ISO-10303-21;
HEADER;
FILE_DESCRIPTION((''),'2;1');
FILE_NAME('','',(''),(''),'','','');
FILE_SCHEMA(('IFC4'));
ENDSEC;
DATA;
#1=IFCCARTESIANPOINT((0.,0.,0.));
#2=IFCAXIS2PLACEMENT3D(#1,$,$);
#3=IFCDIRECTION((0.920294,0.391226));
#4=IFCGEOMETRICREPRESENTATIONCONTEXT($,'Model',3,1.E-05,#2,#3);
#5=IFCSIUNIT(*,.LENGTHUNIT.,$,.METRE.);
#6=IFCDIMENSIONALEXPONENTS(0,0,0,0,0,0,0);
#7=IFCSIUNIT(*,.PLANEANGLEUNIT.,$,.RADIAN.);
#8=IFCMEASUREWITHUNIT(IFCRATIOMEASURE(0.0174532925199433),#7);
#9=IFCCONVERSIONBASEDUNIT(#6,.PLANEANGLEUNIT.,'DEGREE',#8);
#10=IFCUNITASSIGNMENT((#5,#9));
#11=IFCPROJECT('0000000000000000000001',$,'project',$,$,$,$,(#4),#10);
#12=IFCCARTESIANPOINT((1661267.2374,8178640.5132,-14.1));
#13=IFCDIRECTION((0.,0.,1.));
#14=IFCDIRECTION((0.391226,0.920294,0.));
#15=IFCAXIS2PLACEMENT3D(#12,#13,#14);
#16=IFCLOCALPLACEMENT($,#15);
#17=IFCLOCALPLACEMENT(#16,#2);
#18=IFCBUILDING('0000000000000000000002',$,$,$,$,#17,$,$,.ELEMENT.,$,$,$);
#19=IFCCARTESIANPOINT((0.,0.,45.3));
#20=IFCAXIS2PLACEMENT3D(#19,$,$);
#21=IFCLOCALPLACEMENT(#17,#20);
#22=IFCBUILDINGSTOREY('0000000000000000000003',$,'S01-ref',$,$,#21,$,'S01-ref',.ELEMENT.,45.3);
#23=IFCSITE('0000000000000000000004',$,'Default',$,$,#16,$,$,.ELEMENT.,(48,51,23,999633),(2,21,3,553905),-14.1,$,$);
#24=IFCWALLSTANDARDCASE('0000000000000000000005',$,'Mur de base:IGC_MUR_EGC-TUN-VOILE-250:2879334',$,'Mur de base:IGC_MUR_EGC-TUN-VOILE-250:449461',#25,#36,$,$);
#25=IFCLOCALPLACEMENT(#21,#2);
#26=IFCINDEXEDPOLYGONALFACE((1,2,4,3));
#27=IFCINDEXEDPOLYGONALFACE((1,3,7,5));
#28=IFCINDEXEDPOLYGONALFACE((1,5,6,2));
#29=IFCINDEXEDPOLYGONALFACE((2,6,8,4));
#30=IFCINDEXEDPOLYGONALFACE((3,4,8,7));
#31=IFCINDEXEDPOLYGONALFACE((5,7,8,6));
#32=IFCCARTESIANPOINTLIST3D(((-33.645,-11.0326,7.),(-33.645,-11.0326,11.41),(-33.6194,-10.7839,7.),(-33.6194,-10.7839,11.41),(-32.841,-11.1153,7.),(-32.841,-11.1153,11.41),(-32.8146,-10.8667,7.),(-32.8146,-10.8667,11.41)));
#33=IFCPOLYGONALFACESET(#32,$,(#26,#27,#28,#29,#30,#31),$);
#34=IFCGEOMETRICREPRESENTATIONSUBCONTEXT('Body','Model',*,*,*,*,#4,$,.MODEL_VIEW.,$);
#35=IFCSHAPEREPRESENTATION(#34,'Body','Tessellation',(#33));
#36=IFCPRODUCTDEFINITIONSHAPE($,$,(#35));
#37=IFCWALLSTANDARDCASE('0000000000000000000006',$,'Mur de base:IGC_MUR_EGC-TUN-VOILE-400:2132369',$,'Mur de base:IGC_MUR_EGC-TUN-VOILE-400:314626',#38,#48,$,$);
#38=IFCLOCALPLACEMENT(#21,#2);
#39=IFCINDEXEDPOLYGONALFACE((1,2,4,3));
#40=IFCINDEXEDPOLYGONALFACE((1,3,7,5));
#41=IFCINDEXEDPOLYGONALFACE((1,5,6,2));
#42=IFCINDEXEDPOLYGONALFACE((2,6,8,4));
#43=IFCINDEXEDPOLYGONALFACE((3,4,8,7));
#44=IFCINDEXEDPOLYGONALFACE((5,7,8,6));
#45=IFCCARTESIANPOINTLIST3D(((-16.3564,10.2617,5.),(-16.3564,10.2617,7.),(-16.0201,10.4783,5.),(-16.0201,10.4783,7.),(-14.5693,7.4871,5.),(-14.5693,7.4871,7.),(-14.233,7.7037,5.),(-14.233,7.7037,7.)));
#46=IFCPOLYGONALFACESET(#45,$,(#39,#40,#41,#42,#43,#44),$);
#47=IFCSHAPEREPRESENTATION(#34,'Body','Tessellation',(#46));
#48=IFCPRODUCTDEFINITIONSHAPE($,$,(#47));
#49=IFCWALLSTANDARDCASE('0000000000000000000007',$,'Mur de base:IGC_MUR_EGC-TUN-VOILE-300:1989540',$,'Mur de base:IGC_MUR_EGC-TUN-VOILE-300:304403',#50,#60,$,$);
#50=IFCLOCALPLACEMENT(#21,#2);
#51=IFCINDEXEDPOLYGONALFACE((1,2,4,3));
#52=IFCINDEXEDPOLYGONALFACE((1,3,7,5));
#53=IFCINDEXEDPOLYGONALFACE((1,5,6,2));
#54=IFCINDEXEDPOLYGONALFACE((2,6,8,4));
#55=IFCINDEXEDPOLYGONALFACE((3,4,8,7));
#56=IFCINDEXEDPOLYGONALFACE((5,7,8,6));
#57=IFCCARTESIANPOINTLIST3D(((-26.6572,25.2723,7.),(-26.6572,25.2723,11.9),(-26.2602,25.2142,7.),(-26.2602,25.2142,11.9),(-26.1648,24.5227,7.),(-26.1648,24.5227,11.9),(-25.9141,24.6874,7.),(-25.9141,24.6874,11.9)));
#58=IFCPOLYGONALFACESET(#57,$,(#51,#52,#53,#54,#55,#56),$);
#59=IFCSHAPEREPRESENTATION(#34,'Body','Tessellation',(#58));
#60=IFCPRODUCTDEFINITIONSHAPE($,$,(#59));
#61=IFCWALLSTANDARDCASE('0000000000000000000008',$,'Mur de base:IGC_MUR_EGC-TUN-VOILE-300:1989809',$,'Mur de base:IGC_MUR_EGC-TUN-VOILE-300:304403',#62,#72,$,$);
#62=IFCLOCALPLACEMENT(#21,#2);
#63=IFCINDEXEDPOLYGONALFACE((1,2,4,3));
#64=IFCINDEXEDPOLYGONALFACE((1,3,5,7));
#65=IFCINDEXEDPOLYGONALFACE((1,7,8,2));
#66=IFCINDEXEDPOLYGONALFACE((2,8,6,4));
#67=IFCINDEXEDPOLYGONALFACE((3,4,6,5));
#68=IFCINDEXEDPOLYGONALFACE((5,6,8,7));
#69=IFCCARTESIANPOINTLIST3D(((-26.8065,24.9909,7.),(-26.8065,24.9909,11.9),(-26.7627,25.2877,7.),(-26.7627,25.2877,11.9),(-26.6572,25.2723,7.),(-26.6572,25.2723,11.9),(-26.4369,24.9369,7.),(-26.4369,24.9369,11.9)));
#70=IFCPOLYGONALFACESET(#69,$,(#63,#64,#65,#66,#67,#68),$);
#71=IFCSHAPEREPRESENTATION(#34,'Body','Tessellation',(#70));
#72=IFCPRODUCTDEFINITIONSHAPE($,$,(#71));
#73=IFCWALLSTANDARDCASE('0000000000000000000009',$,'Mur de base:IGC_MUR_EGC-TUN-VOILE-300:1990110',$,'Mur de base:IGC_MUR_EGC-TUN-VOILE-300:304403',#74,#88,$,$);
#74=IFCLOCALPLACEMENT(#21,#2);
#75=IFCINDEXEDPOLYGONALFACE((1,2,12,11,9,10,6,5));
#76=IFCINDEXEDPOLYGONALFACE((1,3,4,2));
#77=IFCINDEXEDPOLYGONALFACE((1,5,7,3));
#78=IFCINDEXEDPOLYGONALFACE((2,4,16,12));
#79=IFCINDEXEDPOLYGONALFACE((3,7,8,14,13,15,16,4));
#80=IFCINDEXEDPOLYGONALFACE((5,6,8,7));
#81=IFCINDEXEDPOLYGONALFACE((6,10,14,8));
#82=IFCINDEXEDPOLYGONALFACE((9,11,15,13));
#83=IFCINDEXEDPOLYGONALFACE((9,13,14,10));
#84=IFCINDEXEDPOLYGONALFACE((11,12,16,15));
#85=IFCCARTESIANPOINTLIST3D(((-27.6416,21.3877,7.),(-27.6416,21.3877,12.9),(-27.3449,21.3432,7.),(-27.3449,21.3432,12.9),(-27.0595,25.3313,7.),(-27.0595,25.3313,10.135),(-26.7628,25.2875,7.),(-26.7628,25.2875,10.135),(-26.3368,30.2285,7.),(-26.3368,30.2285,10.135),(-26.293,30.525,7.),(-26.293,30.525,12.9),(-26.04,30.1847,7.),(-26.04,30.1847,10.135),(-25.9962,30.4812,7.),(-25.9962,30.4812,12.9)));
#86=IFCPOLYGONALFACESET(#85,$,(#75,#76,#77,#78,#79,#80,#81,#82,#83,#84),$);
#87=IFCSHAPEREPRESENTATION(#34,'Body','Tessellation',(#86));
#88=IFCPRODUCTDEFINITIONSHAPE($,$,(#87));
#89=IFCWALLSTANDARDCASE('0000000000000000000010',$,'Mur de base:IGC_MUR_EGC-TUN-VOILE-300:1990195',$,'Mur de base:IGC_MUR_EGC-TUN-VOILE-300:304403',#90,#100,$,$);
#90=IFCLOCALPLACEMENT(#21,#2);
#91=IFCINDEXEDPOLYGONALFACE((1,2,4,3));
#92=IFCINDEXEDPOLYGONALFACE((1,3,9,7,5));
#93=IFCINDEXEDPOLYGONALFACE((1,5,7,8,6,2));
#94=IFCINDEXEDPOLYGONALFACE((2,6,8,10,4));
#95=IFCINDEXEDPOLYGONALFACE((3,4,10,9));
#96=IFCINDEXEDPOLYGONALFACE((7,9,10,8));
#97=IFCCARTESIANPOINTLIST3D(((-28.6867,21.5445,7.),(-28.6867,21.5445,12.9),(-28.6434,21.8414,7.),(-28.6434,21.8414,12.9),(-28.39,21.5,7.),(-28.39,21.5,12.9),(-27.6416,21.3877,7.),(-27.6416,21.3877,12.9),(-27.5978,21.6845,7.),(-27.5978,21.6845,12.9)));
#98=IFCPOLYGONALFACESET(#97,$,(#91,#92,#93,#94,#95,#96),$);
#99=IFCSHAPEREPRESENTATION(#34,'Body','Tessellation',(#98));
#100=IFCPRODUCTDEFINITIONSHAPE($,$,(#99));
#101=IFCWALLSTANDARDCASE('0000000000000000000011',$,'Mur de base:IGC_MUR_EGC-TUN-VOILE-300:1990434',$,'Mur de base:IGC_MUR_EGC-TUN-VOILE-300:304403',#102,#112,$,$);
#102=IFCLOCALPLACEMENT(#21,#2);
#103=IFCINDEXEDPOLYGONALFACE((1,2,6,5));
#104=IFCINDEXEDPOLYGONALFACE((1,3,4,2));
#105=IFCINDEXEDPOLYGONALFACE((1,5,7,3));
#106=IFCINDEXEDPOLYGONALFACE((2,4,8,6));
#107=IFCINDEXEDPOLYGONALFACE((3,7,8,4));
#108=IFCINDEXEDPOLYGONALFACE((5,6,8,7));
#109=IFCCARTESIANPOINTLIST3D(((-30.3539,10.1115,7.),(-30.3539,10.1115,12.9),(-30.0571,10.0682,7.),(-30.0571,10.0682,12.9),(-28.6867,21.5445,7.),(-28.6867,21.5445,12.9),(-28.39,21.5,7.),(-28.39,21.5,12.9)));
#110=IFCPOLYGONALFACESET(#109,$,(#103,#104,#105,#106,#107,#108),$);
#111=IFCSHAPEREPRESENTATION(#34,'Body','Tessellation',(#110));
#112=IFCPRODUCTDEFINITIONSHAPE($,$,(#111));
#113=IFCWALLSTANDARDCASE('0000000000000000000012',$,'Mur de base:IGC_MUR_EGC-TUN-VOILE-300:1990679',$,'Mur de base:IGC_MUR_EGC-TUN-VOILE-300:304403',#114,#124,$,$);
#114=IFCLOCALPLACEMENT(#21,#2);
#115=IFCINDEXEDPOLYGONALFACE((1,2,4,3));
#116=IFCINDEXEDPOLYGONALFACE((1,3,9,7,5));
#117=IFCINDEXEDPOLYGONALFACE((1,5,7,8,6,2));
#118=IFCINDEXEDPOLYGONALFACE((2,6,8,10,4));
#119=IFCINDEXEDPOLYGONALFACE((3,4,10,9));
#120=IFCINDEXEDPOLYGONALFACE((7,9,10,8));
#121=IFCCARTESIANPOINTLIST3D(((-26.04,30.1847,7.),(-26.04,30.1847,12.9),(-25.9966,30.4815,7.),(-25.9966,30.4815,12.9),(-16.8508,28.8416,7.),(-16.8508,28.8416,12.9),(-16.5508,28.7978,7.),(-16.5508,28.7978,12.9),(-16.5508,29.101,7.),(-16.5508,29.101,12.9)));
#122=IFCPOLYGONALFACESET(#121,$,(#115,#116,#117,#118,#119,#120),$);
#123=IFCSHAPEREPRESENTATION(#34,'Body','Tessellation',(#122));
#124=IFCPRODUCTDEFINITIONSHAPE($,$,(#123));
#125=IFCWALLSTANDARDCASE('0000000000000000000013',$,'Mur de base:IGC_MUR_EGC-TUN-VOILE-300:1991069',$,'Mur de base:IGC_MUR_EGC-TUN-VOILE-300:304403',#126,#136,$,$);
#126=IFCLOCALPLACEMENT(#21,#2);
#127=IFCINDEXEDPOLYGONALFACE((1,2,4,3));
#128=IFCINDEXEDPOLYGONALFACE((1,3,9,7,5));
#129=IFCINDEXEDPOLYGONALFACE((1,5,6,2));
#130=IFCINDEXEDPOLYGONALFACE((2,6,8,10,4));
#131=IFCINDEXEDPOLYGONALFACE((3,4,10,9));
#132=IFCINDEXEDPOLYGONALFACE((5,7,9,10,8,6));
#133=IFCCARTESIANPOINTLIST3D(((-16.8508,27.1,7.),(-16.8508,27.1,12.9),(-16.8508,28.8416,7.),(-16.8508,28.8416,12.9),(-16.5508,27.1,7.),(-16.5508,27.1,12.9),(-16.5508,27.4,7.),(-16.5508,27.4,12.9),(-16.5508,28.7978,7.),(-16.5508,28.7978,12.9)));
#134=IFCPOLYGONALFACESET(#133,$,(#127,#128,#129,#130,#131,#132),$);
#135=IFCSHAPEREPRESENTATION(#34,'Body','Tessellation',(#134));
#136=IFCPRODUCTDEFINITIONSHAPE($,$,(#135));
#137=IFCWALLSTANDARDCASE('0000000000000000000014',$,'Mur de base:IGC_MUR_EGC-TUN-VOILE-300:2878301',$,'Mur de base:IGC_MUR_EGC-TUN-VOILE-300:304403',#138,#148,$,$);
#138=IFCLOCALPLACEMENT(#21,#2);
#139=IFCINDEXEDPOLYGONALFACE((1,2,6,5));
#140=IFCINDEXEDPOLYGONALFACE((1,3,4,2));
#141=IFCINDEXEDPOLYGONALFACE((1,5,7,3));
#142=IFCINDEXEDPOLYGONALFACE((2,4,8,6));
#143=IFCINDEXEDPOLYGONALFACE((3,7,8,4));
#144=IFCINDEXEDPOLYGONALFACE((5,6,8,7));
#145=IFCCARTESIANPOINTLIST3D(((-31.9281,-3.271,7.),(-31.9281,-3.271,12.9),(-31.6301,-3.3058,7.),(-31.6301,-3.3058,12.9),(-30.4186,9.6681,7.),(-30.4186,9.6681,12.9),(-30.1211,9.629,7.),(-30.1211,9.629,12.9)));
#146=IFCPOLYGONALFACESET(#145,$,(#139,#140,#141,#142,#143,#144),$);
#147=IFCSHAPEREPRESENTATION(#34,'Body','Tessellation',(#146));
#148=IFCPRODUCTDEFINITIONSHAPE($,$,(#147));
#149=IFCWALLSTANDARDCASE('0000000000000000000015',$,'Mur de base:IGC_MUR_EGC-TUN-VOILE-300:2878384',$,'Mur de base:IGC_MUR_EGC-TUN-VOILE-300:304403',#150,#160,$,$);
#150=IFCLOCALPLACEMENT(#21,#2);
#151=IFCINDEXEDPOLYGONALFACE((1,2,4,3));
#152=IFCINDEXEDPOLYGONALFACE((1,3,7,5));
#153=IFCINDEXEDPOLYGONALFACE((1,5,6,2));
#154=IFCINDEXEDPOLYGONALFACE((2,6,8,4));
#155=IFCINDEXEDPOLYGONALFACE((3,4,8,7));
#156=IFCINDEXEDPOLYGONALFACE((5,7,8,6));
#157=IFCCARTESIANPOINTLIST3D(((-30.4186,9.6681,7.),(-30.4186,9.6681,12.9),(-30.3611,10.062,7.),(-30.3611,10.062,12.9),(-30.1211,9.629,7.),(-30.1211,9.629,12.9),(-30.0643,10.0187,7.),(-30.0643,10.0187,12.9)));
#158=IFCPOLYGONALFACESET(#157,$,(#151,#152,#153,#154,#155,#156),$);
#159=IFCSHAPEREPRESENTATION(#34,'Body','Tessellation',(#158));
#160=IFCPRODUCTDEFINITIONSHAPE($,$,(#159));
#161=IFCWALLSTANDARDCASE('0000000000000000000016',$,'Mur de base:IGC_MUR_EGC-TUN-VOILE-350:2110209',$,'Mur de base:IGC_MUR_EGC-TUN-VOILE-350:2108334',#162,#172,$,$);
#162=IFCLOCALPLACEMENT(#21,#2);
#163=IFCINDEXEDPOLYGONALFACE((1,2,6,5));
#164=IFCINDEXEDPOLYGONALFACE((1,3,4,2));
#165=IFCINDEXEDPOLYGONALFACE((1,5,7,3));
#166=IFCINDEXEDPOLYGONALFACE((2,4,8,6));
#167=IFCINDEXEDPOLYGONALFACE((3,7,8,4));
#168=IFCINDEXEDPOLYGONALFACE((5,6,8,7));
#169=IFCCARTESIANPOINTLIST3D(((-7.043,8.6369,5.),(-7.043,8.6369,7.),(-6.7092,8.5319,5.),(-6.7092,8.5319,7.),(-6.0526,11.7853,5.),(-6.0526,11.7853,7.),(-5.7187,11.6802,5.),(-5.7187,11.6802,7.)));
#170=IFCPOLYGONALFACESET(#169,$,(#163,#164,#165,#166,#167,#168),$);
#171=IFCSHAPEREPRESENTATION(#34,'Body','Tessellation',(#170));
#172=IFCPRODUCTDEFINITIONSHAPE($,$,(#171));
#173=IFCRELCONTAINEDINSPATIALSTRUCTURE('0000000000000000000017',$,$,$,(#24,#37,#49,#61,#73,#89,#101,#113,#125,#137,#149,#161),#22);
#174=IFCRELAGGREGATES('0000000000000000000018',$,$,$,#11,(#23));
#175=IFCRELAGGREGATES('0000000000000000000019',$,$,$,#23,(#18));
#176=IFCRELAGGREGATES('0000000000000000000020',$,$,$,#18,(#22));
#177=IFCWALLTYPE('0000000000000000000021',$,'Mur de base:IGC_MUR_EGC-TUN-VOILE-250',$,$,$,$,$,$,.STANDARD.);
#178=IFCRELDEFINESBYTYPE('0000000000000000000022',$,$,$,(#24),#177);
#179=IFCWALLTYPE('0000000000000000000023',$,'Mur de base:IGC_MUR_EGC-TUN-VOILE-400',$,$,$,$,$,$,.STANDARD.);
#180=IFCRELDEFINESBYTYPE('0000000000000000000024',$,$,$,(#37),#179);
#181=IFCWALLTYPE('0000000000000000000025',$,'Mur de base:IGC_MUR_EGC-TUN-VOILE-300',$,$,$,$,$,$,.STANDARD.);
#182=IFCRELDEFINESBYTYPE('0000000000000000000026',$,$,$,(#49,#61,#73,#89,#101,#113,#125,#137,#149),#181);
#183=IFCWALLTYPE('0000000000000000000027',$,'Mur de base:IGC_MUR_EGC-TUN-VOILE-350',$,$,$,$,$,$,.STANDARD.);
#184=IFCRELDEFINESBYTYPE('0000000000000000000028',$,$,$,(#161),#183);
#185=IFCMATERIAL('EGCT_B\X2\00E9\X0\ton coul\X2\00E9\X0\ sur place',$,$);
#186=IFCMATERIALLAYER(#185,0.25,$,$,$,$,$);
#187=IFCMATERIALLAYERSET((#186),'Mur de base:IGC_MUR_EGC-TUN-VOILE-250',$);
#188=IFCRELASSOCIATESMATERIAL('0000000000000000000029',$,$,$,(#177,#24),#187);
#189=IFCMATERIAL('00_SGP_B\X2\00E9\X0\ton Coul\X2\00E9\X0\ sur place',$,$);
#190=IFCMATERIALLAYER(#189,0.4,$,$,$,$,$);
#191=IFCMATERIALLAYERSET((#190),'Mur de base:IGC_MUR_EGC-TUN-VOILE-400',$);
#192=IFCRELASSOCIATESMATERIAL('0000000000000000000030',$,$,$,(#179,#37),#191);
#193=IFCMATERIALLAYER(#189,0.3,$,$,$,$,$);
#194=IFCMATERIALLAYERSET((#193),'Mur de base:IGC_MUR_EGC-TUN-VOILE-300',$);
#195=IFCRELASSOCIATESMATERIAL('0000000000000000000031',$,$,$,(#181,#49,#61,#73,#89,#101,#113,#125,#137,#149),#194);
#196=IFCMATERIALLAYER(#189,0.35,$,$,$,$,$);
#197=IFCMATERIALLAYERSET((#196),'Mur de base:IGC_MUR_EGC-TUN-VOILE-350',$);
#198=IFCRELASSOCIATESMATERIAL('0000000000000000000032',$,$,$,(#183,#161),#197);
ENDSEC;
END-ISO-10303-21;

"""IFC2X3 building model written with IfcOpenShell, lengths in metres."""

from ifc_helpers import new_model, entity, si_unit, converted_unit, direction, frame, frame_2d, origin, place, context, subcontext, project, spatial, polyline, rectangle, outline, extrude, clip, bounded_halfspace, material, layer, layer_set, layer_usage, type_object, element, save


model = new_model("IFC2X3")

# Units and contexts
model_context = context("Model", 3, precision=1e-05, world=origin(), true_north=direction((0.920294, 0.391226)))
body_context = subcontext(model_context, "Body", "Model", "MODEL_VIEW")
ifc_project = project(units=[si_unit("LENGTHUNIT", "METRE"), converted_unit("PLANEANGLEUNIT", "DEGREE", entity("IfcRatioMeasure", 0.0174532925199433), si_unit("PLANEANGLEUNIT", "RADIAN"), dimensions=[0, 0, 0, 0, 0, 0, 0])], contexts=[model_context])

# Site, building, storey
site_placement = place(None, frame((1661267.2374, 8178640.5132, -14.1), z_axis=(0.0, 0.0, 1.0), x_axis=(0.391226, 0.920294, 0.0)))
site = spatial("IfcSite", under=ifc_project, at=site_placement, Name="Default", CompositionType="ELEMENT", RefLatitude=(48, 51, 23, 999633), RefLongitude=(2, 21, 3, 553905), RefElevation=-14.1)
building_placement = place(site_placement, origin())
building = spatial("IfcBuilding", under=site, at=building_placement, CompositionType="ELEMENT")
storey_placement = place(building_placement, frame((0.0, 0.0, 45.3)))
storey = spatial("IfcBuildingStorey", under=building, at=storey_placement, Name="S01-ref", LongName="S01-ref", CompositionType="ELEMENT", Elevation=45.3)

# Walls
ifc_material_1 = material(Name="00_SGP_Béton Coulé sur place")
ifc_material_2 = material(Name="EGCT_Béton coulé sur place")
ifc_layer_1 = layer(ifc_material_2, 0.25)
ifc_layer_set_1 = layer_set([ifc_layer_1], Name="Mur de base:IGC_MUR_EGC-TUN-VOILE-250")
ifc_layer_usage_1 = layer_usage(ifc_layer_set_1, "AXIS2", "POSITIVE", -0.125)
wall_type_1 = type_object("IfcWallType", Name="Mur de base:IGC_MUR_EGC-TUN-VOILE-250", PredefinedType="STANDARD", material=ifc_layer_set_1)
wall_1_placement = place(storey_placement, frame((-33.6322, -10.9082, 7.0), z_axis=(0.0, 0.0, 1.0), x_axis=(0.994745, -0.102383, 0.0)))
element("IfcWallStandardCase", 1, at=wall_1_placement, inside=storey, type_object=wall_type_1, material=ifc_layer_usage_1, Name="Mur de base:IGC_MUR_EGC-TUN-VOILE-250:2879334", ObjectType="Mur de base:IGC_MUR_EGC-TUN-VOILE-250:449461", context=body_context, shape_type="SweptSolid", body=[
    extrude(outline(polyline([(0.8083, -0.125), (0.8091, 0.125), (0.0, 0.125), (0.0, -0.125), (0.8083, -0.125)])), origin(), (0.0, 0.0, 1.0), 4.41),
])
ifc_layer_2 = layer(ifc_material_1, 0.4)
ifc_layer_set_2 = layer_set([ifc_layer_2], Name="Mur de base:IGC_MUR_EGC-TUN-VOILE-400")
ifc_layer_usage_2 = layer_usage(ifc_layer_set_2, "AXIS2", "POSITIVE", -0.2)
wall_type_2 = type_object("IfcWallType", Name="Mur de base:IGC_MUR_EGC-TUN-VOILE-400", PredefinedType="STANDARD", material=ifc_layer_set_2)
wall_2_placement = place(storey_placement, frame((-14.4011, 7.5954, 5.0), z_axis=(0.0, 0.0, 1.0), x_axis=(-0.541486, 0.84071, 0.0)))
element("IfcWallStandardCase", 2, at=wall_2_placement, inside=storey, type_object=wall_type_2, material=ifc_layer_usage_2, Name="Mur de base:IGC_MUR_EGC-TUN-VOILE-400:2132369", ObjectType="Mur de base:IGC_MUR_EGC-TUN-VOILE-400:314626", context=body_context, shape_type="SweptSolid", body=[
    extrude(rectangle(XDim=3.3004, YDim=0.4, at=frame_2d((1.6502, 0.0), x_axis=(-1.0, 0.0))), origin(), (0.0, 0.0, 1.0), 2.0),
])

# Shared definitions
ifc_layer_3 = layer(ifc_material_1, 0.3)
ifc_layer_set_3 = layer_set([ifc_layer_3], Name="Mur de base:IGC_MUR_EGC-TUN-VOILE-300")
wall_type_3 = type_object("IfcWallType", Name="Mur de base:IGC_MUR_EGC-TUN-VOILE-300", PredefinedType="STANDARD", material=ifc_layer_set_3)

# Walls
ifc_layer_usage_3 = layer_usage(ifc_layer_set_3, "AXIS2", "POSITIVE", -0.15)
wall_3_placement = place(storey_placement, frame((-26.0394, 24.605, 7.0), z_axis=(0.0, 0.0, 1.0), x_axis=(-0.549039, 0.835797, 0.0)))
element("IfcWallStandardCase", 3, at=wall_3_placement, inside=storey, type_object=wall_type_3, material=ifc_layer_usage_3, Name="Mur de base:IGC_MUR_EGC-TUN-VOILE-300:1989540", ObjectType="Mur de base:IGC_MUR_EGC-TUN-VOILE-300:304403", context=body_context, shape_type="Clipping", body=[
    clip(extrude(outline(polyline([(0.6304, -0.15), (0.8969, 0.15), (0.4956, 0.15), (0.0, 0.15), (0.0, -0.15), (0.6304, -0.15)])), origin(), (0.0, 0.0, 1.0), 4.9), bounded_halfspace(frame((0.0, -0.15, 4.9), z_axis=(0.0, 0.0, -1.0), x_axis=(0.882192, 0.47089, 0.0)), True, frame((0.0, -0.15, 4.9)), polyline([(0.0, 0.0), (0.6304, 0.0), (0.8969, 0.3), (0.4956, 0.3), (0.0, 0.3), (0.0, 0.0)]))),
])
ifc_layer_usage_4 = layer_usage(ifc_layer_set_3, "AXIS2", "POSITIVE", -0.15)
wall_4_placement = place(storey_placement, frame((-26.4152, 25.0853, 7.0), z_axis=(0.0, 0.0, 1.0), x_axis=(-0.989488, 0.144616, 0.0)))
element("IfcWallStandardCase", 4, at=wall_4_placement, inside=storey, type_object=wall_type_3, material=ifc_layer_usage_4, Name="Mur de base:IGC_MUR_EGC-TUN-VOILE-300:1989809", ObjectType="Mur de base:IGC_MUR_EGC-TUN-VOILE-300:304403", context=body_context, shape_type="Clipping", body=[
    clip(extrude(outline(polyline([(0.3732, -0.15), (0.3732, -0.1498), (0.3736, 0.15), (0.0, 0.15), (0.2665, -0.15), (0.3732, -0.15)])), origin(), (0.0, 0.0, 1.0), 4.9), bounded_halfspace(frame((0.2665, -0.15, 4.9), z_axis=(0.0, 0.0, -1.0), x_axis=(0.937939, -0.3468, 0.0)), True, frame((0.2665, -0.15, 4.9)), polyline([(0.0, 0.0), (0.1066, 0.0), (0.1071, 0.3), (-0.2665, 0.3), (0.0, 0.0)]))),
])

# Wall, opening
ifc_layer_usage_5 = layer_usage(ifc_layer_set_3, "AXIS2", "POSITIVE", -0.15)
wall_5_placement = place(storey_placement, frame((-26.1446, 30.5031, 7.0), z_axis=(0.0, 0.0, 1.0), x_axis=(-0.146005, -0.989284, 0.0)))
wall_5 = element("IfcWallStandardCase", 5, at=wall_5_placement, inside=storey, type_object=wall_type_3, material=ifc_layer_usage_5, Name="Mur de base:IGC_MUR_EGC-TUN-VOILE-300:1990110", ObjectType="Mur de base:IGC_MUR_EGC-TUN-VOILE-300:304403", context=body_context, shape_type="SweptSolid", body=[
    extrude(outline(polyline([(0.0, -0.15), (8.9363, -0.15), (9.2363, -0.15), (9.237, 0.15), (0.0, 0.15), (0.0, -0.15)])), origin(), (0.0, 0.0, 1.0), 5.9),
])
opening_1_placement = place(wall_5_placement, origin())
element("IfcOpeningElement", 6, at=opening_1_placement, cuts=wall_5, ObjectType="Opening", context=body_context, shape_type="SweptSolid", body=[
    extrude(rectangle(XDim=3.135, YDim=4.9502, at=frame_2d((0.0, 0.0), x_axis=(0.0, 1.0))), frame((2.7749, -1.674, 1.5675), z_axis=(0.0, 1.0, 0.0), x_axis=(1.0, 0.0, 0.0)), (0.0, 0.0, 1.0), 3.048),
])

# Walls
ifc_layer_usage_6 = layer_usage(ifc_layer_set_3, "AXIS2", "POSITIVE", -0.15)
wall_6_placement = place(storey_placement, frame((-27.6193, 21.536, 7.0), z_axis=(0.0, 0.0, 1.0), x_axis=(-0.988927, 0.148402, 0.0)))
element("IfcWallStandardCase", 7, at=wall_6_placement, inside=storey, type_object=wall_type_3, material=ifc_layer_usage_6, Name="Mur de base:IGC_MUR_EGC-TUN-VOILE-300:1990195", ObjectType="Mur de base:IGC_MUR_EGC-TUN-VOILE-300:304403", context=body_context, shape_type="SweptSolid", body=[
    extrude(outline(polyline([(1.0581, -0.15), (1.0568, 0.15), (0.7568, 0.15), (0.0, 0.15), (0.0007, -0.15), (1.0581, -0.15)])), origin(), (0.0, 0.0, 1.0), 5.9),
])
ifc_layer_usage_7 = layer_usage(ifc_layer_set_3, "AXIS2", "POSITIVE", -0.15)
wall_7_placement = place(storey_placement, frame((-28.5383, 21.5229, 7.0), z_axis=(0.0, 0.0, 1.0), x_axis=(-0.144299, -0.989534, 0.0)))
element("IfcWallStandardCase", 8, at=wall_7_placement, inside=storey, type_object=wall_type_3, material=ifc_layer_usage_7, Name="Mur de base:IGC_MUR_EGC-TUN-VOILE-300:1990434", ObjectType="Mur de base:IGC_MUR_EGC-TUN-VOILE-300:304403", context=body_context, shape_type="SweptSolid", body=[
    extrude(outline(polyline([(11.5539, -0.15), (11.5539, 0.15), (0.0012, 0.15), (0.0, -0.15), (11.5539, -0.15)])), origin(), (0.0, 0.0, 1.0), 5.9),
])
ifc_layer_usage_8 = layer_usage(ifc_layer_set_3, "AXIS2", "NEGATIVE", 0.15)
wall_8_placement = place(storey_placement, frame((-16.5291, 28.9462, 7.0), z_axis=(0.0, 0.0, 1.0), x_axis=(-0.989488, 0.144616, 0.0)))
element("IfcWallStandardCase", 9, at=wall_8_placement, inside=storey, type_object=wall_type_3, material=ifc_layer_usage_8, Name="Mur de base:IGC_MUR_EGC-TUN-VOILE-300:1990679", ObjectType="Mur de base:IGC_MUR_EGC-TUN-VOILE-300:304403", context=body_context, shape_type="SweptSolid", body=[
    extrude(outline(polyline([(9.59, -0.15), (9.59, 0.15), (0.3032, 0.15), (0.0, 0.15), (0.0438, -0.15), (9.59, -0.15)])), origin(), (0.0, 0.0, 1.0), 5.9),
])
ifc_layer_usage_9 = layer_usage(ifc_layer_set_3, "AXIS2", "NEGATIVE", 0.15)
wall_9_placement = place(storey_placement, frame((-16.7008, 28.8416, 7.0), z_axis=(0.0, 0.0, 1.0), x_axis=(0.0, -1.0, 0.0)))
element("IfcWallStandardCase", 10, at=wall_9_placement, inside=storey, type_object=wall_type_3, material=ifc_layer_usage_9, Name="Mur de base:IGC_MUR_EGC-TUN-VOILE-300:1991069", ObjectType="Mur de base:IGC_MUR_EGC-TUN-VOILE-300:304403", context=body_context, shape_type="SweptSolid", body=[
    extrude(outline(polyline([(1.7416, -0.15), (1.7416, 0.15), (1.4416, 0.15), (0.0438, 0.15), (0.0, -0.15), (1.7416, -0.15)])), origin(), (0.0, 0.0, 1.0), 5.9),
])

# Walls
ifc_layer_usage_10 = layer_usage(ifc_layer_set_3, "AXIS2", "NEGATIVE", 0.15)
wall_10_placement = place(storey_placement, frame((-31.7791, -3.2884, 7.0), z_axis=(0.0, 0.0, 1.0), x_axis=(0.115877, 0.993264, 0.0)))
element("IfcWallStandardCase", 11, at=wall_10_placement, inside=storey, type_object=wall_type_3, material=ifc_layer_usage_10, Name="Mur de base:IGC_MUR_EGC-TUN-VOILE-300:2878301", ObjectType="Mur de base:IGC_MUR_EGC-TUN-VOILE-300:304403", context=body_context, shape_type="SweptSolid", body=[
    extrude(outline(polyline([(13.0225, -0.15), (13.0268, 0.15), (0.0, 0.15), (0.0, -0.15), (13.0225, -0.15)])), origin(), (0.0, 0.0, 1.0), 5.9),
])
ifc_layer_usage_11 = layer_usage(ifc_layer_set_3, "AXIS2", "NEGATIVE", 0.15)
wall_11_placement = place(storey_placement, frame((-30.2702, 9.6464, 7.0), z_axis=(0.0, 0.0, 1.0), x_axis=(0.144299, 0.989534, 0.0)))
element("IfcWallStandardCase", 12, at=wall_11_placement, inside=storey, type_object=wall_type_3, material=ifc_layer_usage_11, Name="Mur de base:IGC_MUR_EGC-TUN-VOILE-300:2878384", ObjectType="Mur de base:IGC_MUR_EGC-TUN-VOILE-300:304403", context=body_context, shape_type="SweptSolid", body=[
    extrude(outline(polyline([(0.3981, -0.15), (0.3981, 0.15), (0.0, 0.15), (0.0043, -0.15), (0.3981, -0.15)])), origin(), (0.0, 0.0, 1.0), 5.9),
])
ifc_layer_4 = layer(ifc_material_1, 0.35)
ifc_layer_set_4 = layer_set([ifc_layer_4], Name="Mur de base:IGC_MUR_EGC-TUN-VOILE-350")
ifc_layer_usage_12 = layer_usage(ifc_layer_set_4, "AXIS2", "POSITIVE", -0.175)
wall_type_4 = type_object("IfcWallType", Name="Mur de base:IGC_MUR_EGC-TUN-VOILE-350", PredefinedType="STANDARD", material=ifc_layer_set_4)
wall_12_placement = place(storey_placement, frame((-6.8761, 8.5844, 5.0), z_axis=(0.0, 0.0, 1.0), x_axis=(0.300085, 0.953913, 0.0)))
element("IfcWallStandardCase", 13, at=wall_12_placement, inside=storey, type_object=wall_type_4, material=ifc_layer_usage_12, Name="Mur de base:IGC_MUR_EGC-TUN-VOILE-350:2110209", ObjectType="Mur de base:IGC_MUR_EGC-TUN-VOILE-350:2108334", context=body_context, shape_type="SweptSolid", body=[
    extrude(rectangle(XDim=3.3004, YDim=0.35, at=frame_2d((1.6502, 0.0), x_axis=(-1.0, 0.0))), origin(), (0.0, 0.0, 1.0), 2.0),
])

save(model, "model.ifc")
